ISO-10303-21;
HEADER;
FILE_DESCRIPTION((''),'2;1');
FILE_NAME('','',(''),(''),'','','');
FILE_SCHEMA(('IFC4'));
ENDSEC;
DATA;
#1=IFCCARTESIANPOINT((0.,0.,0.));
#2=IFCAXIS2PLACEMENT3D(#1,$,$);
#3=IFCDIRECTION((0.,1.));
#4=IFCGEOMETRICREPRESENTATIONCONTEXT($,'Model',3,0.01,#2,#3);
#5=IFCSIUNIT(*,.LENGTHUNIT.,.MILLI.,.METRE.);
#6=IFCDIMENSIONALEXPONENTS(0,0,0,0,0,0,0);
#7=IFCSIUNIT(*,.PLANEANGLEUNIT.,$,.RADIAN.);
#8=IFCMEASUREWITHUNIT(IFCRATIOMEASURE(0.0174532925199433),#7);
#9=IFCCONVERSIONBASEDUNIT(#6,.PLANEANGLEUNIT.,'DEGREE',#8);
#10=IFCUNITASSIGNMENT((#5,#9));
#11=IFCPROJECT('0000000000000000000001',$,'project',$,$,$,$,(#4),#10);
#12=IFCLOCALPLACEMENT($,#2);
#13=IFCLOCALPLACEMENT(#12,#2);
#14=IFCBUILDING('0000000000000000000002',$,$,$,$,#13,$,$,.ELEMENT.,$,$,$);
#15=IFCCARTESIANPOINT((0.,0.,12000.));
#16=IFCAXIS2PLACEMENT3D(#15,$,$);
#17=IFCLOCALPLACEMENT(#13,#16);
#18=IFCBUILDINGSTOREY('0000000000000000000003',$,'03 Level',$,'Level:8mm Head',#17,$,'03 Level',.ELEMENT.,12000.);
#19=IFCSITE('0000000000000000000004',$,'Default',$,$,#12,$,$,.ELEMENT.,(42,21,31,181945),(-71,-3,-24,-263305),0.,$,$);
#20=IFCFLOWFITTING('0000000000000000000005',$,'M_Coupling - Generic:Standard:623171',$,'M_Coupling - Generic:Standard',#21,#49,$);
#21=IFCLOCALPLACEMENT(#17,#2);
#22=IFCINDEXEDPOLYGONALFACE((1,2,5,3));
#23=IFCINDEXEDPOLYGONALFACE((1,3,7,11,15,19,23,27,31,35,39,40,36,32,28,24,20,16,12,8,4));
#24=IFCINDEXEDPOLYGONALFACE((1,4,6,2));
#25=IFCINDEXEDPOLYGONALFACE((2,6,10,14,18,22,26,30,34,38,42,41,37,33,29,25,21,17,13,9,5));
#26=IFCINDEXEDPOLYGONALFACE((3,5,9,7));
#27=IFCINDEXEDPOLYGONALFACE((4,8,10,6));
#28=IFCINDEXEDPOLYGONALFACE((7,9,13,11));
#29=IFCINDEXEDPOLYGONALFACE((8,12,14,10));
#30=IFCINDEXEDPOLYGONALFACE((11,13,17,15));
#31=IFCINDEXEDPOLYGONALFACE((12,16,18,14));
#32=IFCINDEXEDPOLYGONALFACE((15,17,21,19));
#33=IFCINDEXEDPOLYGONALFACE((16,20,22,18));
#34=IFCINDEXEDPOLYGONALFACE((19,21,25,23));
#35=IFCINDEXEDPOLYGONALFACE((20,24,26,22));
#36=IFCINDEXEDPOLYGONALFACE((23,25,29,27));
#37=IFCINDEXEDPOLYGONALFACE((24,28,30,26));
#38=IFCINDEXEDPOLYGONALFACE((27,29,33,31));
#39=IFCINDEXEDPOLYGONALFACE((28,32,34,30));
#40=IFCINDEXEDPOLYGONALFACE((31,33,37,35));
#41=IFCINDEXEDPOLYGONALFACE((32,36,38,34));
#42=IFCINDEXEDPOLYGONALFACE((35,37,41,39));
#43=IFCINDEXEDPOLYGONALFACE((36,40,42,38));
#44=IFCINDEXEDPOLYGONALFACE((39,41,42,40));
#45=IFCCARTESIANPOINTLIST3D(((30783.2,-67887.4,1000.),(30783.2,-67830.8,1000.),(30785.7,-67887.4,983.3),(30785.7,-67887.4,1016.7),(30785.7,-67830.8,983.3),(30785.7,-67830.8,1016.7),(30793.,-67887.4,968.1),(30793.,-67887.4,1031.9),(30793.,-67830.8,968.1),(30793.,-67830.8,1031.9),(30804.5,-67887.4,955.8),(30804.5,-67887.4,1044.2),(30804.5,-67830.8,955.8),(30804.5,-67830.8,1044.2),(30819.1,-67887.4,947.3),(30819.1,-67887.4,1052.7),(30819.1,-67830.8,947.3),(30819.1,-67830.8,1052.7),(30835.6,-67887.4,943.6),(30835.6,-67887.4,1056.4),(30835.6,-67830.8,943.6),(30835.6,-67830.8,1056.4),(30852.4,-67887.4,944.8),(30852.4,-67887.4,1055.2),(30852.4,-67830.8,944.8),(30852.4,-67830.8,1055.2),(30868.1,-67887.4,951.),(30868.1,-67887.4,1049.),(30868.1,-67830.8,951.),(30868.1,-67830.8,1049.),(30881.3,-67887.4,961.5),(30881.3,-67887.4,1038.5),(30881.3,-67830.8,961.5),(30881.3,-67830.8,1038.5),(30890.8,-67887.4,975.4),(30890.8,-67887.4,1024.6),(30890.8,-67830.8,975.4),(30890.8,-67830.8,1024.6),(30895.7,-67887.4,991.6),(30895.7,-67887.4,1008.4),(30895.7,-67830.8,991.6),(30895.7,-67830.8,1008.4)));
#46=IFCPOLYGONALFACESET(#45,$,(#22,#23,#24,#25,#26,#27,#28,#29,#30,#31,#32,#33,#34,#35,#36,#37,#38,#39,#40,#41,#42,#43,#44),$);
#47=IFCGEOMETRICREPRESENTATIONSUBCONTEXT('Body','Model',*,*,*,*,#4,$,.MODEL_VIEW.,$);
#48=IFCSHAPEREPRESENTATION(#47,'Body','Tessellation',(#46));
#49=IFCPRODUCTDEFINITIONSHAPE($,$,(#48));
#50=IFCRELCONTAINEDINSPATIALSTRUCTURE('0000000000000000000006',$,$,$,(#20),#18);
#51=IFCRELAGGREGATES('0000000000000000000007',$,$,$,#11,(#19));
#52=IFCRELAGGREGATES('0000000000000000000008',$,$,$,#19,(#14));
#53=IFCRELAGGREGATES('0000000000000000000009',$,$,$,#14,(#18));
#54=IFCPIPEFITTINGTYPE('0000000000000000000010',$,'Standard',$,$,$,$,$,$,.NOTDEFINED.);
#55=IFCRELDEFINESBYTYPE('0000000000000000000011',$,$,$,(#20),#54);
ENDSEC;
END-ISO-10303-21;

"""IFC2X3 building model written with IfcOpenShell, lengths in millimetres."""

from ifc_helpers import new_model, entity, si_unit, converted_unit, direction, frame, frame_2d, origin, place, context, subcontext, project, spatial, circle, extrude, source, transform, mapped, type_object, type_shapes, element, save


model = new_model("IFC2X3")

# Units and contexts
model_context = context("Model", 3, precision=0.01, world=origin(), true_north=direction((0.0, 1.0)))
body_context = subcontext(model_context, "Body", "Model", "MODEL_VIEW")
ifc_project = project(units=[si_unit("LENGTHUNIT", "METRE", prefix="MILLI"), converted_unit("PLANEANGLEUNIT", "DEGREE", entity("IfcRatioMeasure", 0.0174532925199433), si_unit("PLANEANGLEUNIT", "RADIAN"), dimensions=[0, 0, 0, 0, 0, 0, 0])], contexts=[model_context])

# Site, building, storey
site_placement = place(None, origin())
site = spatial("IfcSite", under=ifc_project, at=site_placement, Name="Default", CompositionType="ELEMENT", RefLatitude=(42, 21, 31, 181945), RefLongitude=(-71, -3, -24, -263305), RefElevation=0.0)
building_placement = place(site_placement, origin())
building = spatial("IfcBuilding", under=site, at=building_placement, CompositionType="ELEMENT")
storey_placement = place(building_placement, frame((0.0, 0.0, 12000.0)))
storey = spatial("IfcBuildingStorey", under=building, at=storey_placement, Name="03 Level", ObjectType="Level:8mm Head", LongName="03 Level", CompositionType="ELEMENT", Elevation=12000.0)

# Flow fitting
pipe_fitting_type = type_object("IfcPipeFittingType", Name="Standard", PredefinedType="NOTDEFINED")
shared_shape = source(origin(), body_context, "Body", "SweptSolid", [
    extrude(circle(Radius=56.6, at=frame_2d((0.0, 0.0), x_axis=(1.0, 0.0))), frame((-28.3, 0.0, 0.0), z_axis=(1.0, 0.0, 0.0), x_axis=(0.0, 1.0, 0.0)), (0.0, 0.0, 1.0), 56.6),
])
type_shapes(pipe_fitting_type, [shared_shape])
flow_fitting_placement = place(storey_placement, frame((30839.8, -67859.1, 1000.0), z_axis=(0.0, 0.0, 1.0), x_axis=(0.0, 1.0, 0.0)))
element("IfcFlowFitting", 1, at=flow_fitting_placement, inside=storey, type_object=pipe_fitting_type, Name="M_Coupling - Generic:Standard:623171", ObjectType="M_Coupling - Generic:Standard", context=body_context, shape_type="MappedRepresentation", body=[
    mapped(shared_shape, transform((0.0, 0.0, 0.0), scale=1.0)),
])

save(model, "model.ifc")
